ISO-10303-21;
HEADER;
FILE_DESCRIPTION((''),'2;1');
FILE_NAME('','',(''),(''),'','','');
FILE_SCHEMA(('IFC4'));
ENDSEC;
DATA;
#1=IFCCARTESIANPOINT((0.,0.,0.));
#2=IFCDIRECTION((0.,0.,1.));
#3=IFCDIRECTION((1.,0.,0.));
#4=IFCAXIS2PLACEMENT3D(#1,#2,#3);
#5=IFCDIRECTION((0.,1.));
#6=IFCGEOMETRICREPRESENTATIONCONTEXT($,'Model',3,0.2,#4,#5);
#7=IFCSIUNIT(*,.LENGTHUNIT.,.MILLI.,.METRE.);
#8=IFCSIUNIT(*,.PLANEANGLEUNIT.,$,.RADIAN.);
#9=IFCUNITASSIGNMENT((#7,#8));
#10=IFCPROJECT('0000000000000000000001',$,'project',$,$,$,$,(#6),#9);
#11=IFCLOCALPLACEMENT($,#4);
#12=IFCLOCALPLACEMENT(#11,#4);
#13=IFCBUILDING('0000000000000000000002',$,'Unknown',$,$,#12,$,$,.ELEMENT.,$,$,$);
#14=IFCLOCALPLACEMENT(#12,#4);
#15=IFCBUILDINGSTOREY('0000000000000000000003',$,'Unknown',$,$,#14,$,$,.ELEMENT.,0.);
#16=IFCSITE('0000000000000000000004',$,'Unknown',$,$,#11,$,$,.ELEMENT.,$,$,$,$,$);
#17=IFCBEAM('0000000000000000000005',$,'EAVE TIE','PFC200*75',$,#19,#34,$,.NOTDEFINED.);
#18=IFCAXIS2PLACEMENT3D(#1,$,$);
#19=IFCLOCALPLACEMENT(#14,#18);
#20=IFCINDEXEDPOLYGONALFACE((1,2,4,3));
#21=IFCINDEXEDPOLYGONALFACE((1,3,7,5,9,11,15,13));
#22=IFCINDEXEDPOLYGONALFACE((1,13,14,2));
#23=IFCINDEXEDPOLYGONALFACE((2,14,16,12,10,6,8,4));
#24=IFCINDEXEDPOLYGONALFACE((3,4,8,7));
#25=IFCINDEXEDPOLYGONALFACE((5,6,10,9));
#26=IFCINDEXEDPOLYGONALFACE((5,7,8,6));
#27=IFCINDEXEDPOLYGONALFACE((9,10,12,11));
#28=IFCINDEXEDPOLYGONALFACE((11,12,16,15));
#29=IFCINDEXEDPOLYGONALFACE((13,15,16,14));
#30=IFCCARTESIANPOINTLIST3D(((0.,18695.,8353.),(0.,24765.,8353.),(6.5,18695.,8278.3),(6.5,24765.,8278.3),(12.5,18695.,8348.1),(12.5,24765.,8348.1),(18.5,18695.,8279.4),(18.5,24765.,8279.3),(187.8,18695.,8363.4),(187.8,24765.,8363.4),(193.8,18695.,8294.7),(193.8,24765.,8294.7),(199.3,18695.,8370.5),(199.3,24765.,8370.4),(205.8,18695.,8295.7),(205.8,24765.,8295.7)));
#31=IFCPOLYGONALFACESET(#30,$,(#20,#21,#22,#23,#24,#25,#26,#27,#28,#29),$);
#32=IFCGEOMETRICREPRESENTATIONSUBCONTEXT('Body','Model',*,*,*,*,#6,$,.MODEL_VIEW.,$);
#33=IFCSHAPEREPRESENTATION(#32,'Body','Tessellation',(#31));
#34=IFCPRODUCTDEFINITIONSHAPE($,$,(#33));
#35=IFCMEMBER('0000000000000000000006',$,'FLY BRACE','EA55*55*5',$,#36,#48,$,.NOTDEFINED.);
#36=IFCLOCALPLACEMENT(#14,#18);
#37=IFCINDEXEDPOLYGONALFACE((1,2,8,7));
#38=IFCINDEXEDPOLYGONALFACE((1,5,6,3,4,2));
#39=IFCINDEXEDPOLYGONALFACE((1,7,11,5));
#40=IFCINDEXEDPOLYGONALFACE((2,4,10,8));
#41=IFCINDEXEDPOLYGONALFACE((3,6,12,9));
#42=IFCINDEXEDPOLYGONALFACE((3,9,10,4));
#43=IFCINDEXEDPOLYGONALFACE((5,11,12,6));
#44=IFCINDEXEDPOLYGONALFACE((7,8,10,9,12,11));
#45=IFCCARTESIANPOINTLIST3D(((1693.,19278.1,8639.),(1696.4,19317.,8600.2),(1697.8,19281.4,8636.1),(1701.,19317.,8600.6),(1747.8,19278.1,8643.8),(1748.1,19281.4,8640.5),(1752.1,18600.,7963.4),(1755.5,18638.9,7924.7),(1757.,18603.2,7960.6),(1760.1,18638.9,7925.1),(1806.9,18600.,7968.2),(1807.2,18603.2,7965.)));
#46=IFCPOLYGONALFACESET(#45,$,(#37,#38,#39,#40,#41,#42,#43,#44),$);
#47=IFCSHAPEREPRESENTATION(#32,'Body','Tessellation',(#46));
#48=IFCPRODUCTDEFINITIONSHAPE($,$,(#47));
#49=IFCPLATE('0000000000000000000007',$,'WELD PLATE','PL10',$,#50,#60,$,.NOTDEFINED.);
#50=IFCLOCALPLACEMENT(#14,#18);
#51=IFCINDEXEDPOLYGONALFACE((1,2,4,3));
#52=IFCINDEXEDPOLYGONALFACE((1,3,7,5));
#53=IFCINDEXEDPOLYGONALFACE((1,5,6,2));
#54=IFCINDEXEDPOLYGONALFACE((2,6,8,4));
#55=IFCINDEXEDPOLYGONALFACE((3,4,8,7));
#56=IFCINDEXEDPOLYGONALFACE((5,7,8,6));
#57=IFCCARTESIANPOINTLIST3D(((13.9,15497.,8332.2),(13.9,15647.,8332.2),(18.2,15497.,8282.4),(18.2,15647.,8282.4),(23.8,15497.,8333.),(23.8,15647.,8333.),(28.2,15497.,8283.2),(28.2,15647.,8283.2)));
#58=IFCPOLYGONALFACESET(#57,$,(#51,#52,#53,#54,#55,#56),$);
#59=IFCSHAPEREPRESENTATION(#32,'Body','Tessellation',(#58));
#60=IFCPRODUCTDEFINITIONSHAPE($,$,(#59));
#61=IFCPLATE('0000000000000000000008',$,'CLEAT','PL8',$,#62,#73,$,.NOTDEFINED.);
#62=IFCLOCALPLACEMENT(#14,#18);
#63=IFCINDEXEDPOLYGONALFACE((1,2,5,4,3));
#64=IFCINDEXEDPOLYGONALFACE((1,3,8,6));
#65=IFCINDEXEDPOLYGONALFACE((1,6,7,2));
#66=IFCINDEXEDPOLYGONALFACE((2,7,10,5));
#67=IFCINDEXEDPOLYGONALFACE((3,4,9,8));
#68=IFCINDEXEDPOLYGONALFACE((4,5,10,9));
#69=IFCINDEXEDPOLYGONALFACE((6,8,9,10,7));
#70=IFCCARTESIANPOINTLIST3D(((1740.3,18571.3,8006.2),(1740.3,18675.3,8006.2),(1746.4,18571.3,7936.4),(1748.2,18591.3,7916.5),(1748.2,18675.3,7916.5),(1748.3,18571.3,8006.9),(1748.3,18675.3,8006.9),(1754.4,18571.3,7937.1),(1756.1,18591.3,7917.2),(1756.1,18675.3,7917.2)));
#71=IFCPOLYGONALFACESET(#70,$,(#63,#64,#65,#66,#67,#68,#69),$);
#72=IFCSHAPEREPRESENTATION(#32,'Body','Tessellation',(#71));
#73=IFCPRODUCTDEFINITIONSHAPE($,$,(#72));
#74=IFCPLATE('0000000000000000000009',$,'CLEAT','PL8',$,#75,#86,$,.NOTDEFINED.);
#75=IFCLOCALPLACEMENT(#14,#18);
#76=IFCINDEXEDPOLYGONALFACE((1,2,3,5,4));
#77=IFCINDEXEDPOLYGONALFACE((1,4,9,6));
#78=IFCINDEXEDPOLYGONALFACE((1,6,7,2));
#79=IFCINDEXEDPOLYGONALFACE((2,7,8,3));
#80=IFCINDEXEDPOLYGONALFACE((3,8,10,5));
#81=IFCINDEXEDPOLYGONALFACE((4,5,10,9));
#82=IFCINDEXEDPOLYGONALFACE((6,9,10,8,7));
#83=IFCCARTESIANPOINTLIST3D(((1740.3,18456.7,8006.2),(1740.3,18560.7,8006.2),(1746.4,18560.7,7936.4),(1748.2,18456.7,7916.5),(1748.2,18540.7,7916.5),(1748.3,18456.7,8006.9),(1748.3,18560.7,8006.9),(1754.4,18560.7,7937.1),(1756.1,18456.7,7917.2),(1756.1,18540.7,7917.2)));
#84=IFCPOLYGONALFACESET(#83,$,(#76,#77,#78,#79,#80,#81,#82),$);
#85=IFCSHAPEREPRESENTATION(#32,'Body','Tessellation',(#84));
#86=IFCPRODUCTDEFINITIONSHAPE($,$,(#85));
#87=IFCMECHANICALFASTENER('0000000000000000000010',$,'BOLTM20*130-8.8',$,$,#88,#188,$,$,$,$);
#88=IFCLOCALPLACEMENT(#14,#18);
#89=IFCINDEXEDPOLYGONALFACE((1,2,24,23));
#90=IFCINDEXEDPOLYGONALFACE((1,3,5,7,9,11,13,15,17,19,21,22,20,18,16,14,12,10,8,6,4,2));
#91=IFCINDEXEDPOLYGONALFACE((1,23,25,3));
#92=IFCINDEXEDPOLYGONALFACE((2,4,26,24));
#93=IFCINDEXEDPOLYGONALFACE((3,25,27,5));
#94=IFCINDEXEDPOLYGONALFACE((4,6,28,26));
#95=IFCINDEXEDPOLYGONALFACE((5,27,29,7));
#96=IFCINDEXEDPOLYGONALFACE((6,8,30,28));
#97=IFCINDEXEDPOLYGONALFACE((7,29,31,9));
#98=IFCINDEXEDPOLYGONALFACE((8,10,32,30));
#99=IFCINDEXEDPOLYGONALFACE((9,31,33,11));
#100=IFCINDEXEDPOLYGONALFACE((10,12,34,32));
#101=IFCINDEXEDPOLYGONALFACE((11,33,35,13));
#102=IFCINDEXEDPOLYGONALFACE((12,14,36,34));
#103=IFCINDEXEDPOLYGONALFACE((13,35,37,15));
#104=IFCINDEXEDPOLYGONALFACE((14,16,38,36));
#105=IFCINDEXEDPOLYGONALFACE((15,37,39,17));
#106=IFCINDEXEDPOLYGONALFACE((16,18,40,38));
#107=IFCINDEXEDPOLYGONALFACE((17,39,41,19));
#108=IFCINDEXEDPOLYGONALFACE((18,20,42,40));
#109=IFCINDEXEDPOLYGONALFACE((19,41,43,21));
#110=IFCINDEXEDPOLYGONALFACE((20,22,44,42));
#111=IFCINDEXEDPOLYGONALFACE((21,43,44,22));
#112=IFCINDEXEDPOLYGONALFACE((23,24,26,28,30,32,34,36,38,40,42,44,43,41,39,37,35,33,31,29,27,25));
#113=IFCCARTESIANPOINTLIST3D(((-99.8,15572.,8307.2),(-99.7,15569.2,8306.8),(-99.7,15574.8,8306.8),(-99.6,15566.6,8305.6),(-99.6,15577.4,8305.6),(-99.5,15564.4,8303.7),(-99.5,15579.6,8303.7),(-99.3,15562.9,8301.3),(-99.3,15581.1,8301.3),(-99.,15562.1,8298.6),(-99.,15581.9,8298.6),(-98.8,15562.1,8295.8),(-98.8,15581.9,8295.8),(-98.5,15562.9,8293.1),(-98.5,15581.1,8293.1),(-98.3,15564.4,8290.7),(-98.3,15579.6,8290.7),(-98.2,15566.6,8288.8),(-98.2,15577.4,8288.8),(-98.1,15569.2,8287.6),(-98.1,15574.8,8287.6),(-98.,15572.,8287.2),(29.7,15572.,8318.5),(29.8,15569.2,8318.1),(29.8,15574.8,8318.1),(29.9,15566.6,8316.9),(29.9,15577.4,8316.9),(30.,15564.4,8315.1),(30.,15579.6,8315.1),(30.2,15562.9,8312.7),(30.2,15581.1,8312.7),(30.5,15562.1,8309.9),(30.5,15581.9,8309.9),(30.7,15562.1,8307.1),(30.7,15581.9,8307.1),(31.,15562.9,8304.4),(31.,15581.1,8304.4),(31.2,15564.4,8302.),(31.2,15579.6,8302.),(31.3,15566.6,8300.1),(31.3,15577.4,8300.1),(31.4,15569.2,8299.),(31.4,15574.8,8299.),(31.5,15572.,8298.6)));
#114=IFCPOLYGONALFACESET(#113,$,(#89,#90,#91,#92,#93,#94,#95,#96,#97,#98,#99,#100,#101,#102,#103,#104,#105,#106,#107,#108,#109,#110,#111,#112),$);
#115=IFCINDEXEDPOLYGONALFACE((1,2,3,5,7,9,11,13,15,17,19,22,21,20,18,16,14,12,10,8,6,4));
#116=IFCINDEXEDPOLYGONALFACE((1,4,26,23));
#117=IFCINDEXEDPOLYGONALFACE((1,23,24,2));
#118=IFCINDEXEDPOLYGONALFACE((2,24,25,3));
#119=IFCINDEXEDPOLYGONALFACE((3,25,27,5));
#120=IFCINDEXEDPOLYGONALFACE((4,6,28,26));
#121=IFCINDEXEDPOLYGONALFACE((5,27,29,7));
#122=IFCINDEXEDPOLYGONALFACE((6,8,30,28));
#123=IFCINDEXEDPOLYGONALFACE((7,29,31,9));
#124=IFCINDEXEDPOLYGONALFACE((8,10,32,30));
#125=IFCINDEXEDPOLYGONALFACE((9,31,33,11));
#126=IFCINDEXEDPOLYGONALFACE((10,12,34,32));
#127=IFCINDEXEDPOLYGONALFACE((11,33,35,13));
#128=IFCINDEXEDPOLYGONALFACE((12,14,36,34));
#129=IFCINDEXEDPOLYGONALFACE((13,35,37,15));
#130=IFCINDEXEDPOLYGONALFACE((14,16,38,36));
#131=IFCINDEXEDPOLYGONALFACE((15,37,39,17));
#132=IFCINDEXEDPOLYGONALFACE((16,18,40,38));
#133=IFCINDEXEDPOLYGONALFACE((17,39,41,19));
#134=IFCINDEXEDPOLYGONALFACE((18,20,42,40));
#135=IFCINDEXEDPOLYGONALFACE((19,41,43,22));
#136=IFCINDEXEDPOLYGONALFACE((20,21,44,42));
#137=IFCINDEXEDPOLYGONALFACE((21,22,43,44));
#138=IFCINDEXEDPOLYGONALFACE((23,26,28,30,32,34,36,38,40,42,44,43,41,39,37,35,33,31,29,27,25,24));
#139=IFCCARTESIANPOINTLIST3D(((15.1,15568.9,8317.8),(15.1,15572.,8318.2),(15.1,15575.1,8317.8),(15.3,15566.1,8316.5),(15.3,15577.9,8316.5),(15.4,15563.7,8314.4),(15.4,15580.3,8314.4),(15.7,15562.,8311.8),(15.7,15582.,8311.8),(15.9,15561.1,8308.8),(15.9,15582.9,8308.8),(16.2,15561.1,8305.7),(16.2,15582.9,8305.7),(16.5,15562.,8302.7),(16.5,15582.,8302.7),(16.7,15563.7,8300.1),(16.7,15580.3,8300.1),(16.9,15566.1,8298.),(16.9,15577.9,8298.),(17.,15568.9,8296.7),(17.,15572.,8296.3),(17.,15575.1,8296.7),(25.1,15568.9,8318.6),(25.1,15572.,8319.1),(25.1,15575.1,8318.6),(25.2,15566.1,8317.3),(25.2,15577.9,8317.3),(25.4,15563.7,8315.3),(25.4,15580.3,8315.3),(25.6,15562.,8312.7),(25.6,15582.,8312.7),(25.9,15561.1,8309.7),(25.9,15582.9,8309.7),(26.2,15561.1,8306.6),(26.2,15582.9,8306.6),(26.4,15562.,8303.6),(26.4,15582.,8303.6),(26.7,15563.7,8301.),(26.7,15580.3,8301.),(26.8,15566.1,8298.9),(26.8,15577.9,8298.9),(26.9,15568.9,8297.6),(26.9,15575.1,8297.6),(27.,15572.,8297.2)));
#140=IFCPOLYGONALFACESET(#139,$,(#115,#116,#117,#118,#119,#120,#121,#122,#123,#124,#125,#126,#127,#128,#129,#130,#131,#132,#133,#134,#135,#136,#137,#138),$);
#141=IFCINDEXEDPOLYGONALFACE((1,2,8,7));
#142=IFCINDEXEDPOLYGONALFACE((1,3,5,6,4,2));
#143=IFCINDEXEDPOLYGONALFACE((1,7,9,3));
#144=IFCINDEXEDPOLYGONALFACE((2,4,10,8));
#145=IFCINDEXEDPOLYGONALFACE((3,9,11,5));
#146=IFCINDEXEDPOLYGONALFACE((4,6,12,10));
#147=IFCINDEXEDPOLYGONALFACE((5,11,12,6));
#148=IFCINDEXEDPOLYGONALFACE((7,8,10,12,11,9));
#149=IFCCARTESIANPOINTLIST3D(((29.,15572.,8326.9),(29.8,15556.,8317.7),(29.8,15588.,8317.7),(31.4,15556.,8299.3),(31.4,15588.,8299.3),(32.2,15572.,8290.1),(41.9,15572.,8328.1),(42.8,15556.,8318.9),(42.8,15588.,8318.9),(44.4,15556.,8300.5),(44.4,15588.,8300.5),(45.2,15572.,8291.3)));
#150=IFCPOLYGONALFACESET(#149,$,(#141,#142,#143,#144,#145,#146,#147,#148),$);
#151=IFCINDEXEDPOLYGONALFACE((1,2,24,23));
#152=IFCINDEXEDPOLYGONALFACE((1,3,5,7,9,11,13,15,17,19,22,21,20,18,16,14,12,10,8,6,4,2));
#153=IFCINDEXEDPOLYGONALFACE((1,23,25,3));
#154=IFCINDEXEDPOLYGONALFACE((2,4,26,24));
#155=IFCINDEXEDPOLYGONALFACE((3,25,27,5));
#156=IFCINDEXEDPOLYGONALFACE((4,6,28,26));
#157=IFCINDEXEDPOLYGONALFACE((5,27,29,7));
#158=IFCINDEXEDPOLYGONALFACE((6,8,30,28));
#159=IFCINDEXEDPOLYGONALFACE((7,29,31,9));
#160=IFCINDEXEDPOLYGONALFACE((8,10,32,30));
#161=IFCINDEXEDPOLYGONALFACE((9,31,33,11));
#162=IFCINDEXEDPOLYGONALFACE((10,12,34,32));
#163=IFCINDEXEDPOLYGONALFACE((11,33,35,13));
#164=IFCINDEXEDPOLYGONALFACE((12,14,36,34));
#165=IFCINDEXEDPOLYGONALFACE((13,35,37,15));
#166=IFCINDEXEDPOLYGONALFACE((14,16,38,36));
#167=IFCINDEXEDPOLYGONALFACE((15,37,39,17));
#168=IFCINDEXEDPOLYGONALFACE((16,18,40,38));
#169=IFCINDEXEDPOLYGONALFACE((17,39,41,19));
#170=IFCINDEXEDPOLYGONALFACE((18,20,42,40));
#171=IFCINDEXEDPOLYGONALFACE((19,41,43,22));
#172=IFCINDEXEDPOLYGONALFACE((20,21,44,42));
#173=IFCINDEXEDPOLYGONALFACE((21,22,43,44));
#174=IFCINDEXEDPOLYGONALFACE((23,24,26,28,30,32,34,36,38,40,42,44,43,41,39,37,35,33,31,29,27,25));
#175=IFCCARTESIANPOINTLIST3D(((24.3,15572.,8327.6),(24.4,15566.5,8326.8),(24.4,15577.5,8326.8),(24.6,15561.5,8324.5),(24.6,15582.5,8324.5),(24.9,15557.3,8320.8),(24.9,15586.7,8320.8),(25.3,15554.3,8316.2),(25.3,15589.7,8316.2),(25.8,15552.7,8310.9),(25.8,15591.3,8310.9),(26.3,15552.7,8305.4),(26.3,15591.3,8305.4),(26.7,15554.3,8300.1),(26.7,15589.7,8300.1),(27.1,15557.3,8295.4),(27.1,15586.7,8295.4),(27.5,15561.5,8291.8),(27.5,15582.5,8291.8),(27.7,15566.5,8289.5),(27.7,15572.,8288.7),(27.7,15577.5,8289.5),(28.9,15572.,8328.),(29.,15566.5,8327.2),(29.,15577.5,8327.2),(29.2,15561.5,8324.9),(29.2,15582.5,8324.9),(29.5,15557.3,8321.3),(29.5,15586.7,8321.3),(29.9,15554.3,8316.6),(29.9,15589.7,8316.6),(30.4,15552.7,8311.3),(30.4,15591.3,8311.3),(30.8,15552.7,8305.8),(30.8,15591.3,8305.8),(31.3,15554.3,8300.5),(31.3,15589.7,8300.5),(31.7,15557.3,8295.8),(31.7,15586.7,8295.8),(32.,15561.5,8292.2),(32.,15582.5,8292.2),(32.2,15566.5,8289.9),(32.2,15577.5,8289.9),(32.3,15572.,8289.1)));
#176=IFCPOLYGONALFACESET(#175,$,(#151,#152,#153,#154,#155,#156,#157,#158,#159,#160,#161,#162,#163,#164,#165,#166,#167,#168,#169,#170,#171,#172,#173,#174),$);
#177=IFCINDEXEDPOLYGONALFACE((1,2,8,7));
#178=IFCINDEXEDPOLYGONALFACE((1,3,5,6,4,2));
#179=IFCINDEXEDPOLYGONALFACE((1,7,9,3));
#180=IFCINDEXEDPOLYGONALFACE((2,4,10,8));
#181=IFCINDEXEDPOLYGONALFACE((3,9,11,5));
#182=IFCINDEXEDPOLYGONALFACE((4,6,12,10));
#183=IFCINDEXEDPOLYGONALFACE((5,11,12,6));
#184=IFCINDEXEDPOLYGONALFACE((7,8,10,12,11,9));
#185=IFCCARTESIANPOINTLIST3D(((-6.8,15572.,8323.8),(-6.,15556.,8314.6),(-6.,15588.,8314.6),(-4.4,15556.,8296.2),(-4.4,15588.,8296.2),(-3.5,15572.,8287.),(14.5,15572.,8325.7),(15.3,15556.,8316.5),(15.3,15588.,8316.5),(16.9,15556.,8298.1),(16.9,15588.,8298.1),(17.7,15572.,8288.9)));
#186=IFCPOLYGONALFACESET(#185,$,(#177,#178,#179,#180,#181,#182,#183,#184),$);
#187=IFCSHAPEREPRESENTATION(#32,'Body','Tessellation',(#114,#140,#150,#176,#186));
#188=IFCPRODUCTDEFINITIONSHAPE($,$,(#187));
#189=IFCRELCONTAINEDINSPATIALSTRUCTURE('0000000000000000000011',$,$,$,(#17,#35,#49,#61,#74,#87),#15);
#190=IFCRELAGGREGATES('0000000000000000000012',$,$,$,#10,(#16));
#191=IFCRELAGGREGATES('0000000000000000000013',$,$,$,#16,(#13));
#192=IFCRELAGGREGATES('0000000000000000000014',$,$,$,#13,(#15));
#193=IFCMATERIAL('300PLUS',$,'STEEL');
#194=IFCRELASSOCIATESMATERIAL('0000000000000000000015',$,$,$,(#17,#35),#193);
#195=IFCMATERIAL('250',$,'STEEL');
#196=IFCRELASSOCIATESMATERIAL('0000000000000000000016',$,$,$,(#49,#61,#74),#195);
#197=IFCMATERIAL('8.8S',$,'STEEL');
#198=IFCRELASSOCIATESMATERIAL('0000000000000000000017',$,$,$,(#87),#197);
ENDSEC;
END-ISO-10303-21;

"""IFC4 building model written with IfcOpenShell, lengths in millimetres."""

from ifc_helpers import new_model, si_unit, direction, frame, origin_with_axes, place, context, subcontext, project, spatial, line, arc, indexed_curve, outline, extrude, source, transform, mapped, material, element, save


model = new_model("IFC4")

# Units and contexts
model_context = context("Model", 3, precision=0.2, world=origin_with_axes(), true_north=direction((0.0, 1.0)))
body_context = subcontext(model_context, "Body", "Model", "MODEL_VIEW")
ifc_project = project(units=[si_unit("LENGTHUNIT", "METRE", prefix="MILLI"), si_unit("PLANEANGLEUNIT", "RADIAN")], contexts=[model_context])

# Site, building, storey
site_placement = place(None, origin_with_axes())
site = spatial("IfcSite", under=ifc_project, at=site_placement, Name="Unknown", CompositionType="ELEMENT")
building_placement = place(site_placement, origin_with_axes())
building = spatial("IfcBuilding", under=site, at=building_placement, Name="Unknown", CompositionType="ELEMENT")
storey_placement = place(building_placement, origin_with_axes())
storey = spatial("IfcBuildingStorey", under=building, at=storey_placement, Name="Unknown", CompositionType="ELEMENT", Elevation=0.0)

# Beam
ifc_material_1 = material(Name="300PLUS", Category="STEEL")
beam_placement = place(storey_placement, frame((102.9, 18695.0, 8324.4), z_axis=(0.087156, -0.000003, -0.996195), x_axis=(0.0, 1.0, -0.000003)))
element("IfcBeam", 1, at=beam_placement, inside=storey, material=ifc_material_1, Name="EAVE TIE", Description="PFC200*75", PredefinedType="NOTDEFINED", context=body_context, shape_type="SolidModel", body=[
    extrude(outline(indexed_curve([(-37.5, -100.0), (37.5, -100.0), (37.5, -88.0), (-31.5, -88.0), (-31.5, 88.0), (37.5, 88.0), (37.5, 100.0), (-37.5, 100.0)], segments=[line(1, 2, 3, 4, 5, 6, 7, 8, 1)])), frame((0.0, 0.0, 0.0), z_axis=(-1.0, 0.0, 0.0), x_axis=(0.0, 0.0, 1.0)), (0.0, 0.0, -1.0), 6070.0),
])

# Member
member_placement = place(storey_placement, frame((1781.2, 18619.4, 7946.5), z_axis=(0.061629, 0.707107, -0.704416), x_axis=(-0.061629, 0.707107, 0.704416)))
element("IfcMember", 2, at=member_placement, inside=storey, material=ifc_material_1, Name="FLY BRACE", Description="EA55*55*5", PredefinedType="NOTDEFINED", context=body_context, shape_type="SolidModel", body=[
    extrude(outline(indexed_curve([(-27.5, -27.5), (27.5, -27.5), (27.5, -22.9), (-22.9, -22.9), (-22.9, 27.5), (-27.5, 27.5)], segments=[line(1, 2, 3, 4, 5, 6, 1)])), frame((0.0, 0.0, 0.0), z_axis=(-1.0, 0.0, 0.0), x_axis=(0.0, 0.0, 1.0)), (0.0, 0.0, -1.0), 959.0),
])

# Plates
ifc_material_2 = material(Name="250", Category="STEEL")
plate_placement = place(storey_placement, frame((23.2, 15497.0, 8282.8), z_axis=(0.996195, 0.0, 0.087156), x_axis=(0.0, 1.0, 0.0)))
element("IfcPlate", 3, at=plate_placement, inside=storey, material=ifc_material_2, Name="WELD PLATE", Description="PL10", PredefinedType="NOTDEFINED", context=body_context, shape_type="SolidModel", body=[
    extrude(outline(indexed_curve([(0.0, 0.0), (150.0, 0.0), (150.0, 50.0), (0.0, 50.0)], segments=[line(1, 2, 3, 4, 1)])), frame((0.0, 0.0, 5.0), z_axis=(0.0, 0.0, 1.0), x_axis=(1.0, 0.0, 0.0)), (0.0, 0.0, -1.0), 10.0),
])
for number, where, z_axis, x_axis, name in (
    (4, (1752.1, 18571.3, 7916.8), (0.996195, 0.0, 0.087156), (0.0, 1.0, 0.0), "CLEAT"),
    (5, (1752.1, 18560.7, 7916.8), (-0.996195, 0.0, -0.087156), (0.0, -1.0, 0.0), "CLEAT"),
):
    element("IfcPlate", number, at=place(storey_placement, frame(where, z_axis=z_axis, x_axis=x_axis)), inside=storey, material=ifc_material_2, Name=name, Description="PL8", PredefinedType="NOTDEFINED", context=body_context, shape_type="SolidModel", body=[
        extrude(outline(indexed_curve([(0.0, 20.0), (20.0, 0.0), (104.0, 0.0), (104.0, 90.0), (0.0, 90.0)], segments=[line(1, 2, 3, 4, 5, 1)])), frame((0.0, 0.0, 4.0), z_axis=(0.0, 0.0, 1.0), x_axis=(1.0, 0.0, 0.0)), (0.0, 0.0, -1.0), 8.0),
    ])

# Mechanical fastener
ifc_material_3 = material(Name="8.8S", Category="STEEL")
shared_shape_1 = source(origin_with_axes(), body_context, "Body", "SweptSolid", [
    extrude(outline(indexed_curve([(10.0, 0.0), (0.0, 10.0), (-10.0, 0.0), (0.0, -10.0)], segments=[arc(1, 2, 3), arc(3, 4, 1)])), frame((0.0, 0.0, 4.6), z_axis=(0.0, 0.0, -1.0), x_axis=(0.0, 1.0, 0.0)), (0.0, 0.0, 1.0), 130.0),
    extrude(outline(indexed_curve([(11.0, 0.0), (0.0, 11.0), (-11.0, 0.0), (0.0, -11.0)], segments=[arc(1, 2, 3), arc(3, 4, 1)])), frame((0.0, 0.0, 0.0), z_axis=(0.0, 0.0, -1.0), x_axis=(0.0, 1.0, 0.0)), (0.0, 0.0, 1.0), 10.0),
    extrude(outline(indexed_curve([(18.5, 0.0), (9.2, 16.0), (-9.2, 16.0), (-18.5, 0.0), (-9.2, -16.0), (9.2, -16.0)], segments=[line(1, 2, 3, 4, 5, 6, 1)])), frame((0.0, 0.0, 17.6), z_axis=(0.0, 0.0, -1.0), x_axis=(0.0, 1.0, 0.0)), (0.0, 0.0, 1.0), 13.0),
    extrude(outline(indexed_curve([(19.5, 0.0), (0.0, 19.5), (-19.5, 0.0), (0.0, -19.5)], segments=[arc(1, 2, 3), arc(3, 4, 1)])), frame((0.0, 0.0, 4.6), z_axis=(0.0, 0.0, -1.0), x_axis=(0.0, 1.0, 0.0)), (0.0, 0.0, 1.0), 4.6),
    extrude(outline(indexed_curve([(18.5, 0.0), (9.2, 16.0), (-9.2, 16.0), (-18.5, 0.0), (-9.2, -16.0), (9.2, -16.0)], segments=[line(1, 2, 3, 4, 5, 6, 1)])), frame((0.0, 0.0, -10.0), z_axis=(0.0, 0.0, -1.0), x_axis=(0.0, 1.0, 0.0)), (0.0, 0.0, 1.0), 21.3),
])
mechanical_fastener_1_placement = place(storey_placement, frame((26.0, 15572.0, 8308.1), z_axis=(0.996195, 0.0, 0.087156), x_axis=(0.0, 1.0, 0.0)))
element("IfcMechanicalFastener", 6, at=mechanical_fastener_1_placement, inside=storey, material=ifc_material_3, Name="BOLTM20*130-8.8", context=body_context, shape_type="MappedRepresentation", body=[
    mapped(shared_shape_1, transform((0.0, 0.0, 0.0))),
])

save(model, "model.ifc")
